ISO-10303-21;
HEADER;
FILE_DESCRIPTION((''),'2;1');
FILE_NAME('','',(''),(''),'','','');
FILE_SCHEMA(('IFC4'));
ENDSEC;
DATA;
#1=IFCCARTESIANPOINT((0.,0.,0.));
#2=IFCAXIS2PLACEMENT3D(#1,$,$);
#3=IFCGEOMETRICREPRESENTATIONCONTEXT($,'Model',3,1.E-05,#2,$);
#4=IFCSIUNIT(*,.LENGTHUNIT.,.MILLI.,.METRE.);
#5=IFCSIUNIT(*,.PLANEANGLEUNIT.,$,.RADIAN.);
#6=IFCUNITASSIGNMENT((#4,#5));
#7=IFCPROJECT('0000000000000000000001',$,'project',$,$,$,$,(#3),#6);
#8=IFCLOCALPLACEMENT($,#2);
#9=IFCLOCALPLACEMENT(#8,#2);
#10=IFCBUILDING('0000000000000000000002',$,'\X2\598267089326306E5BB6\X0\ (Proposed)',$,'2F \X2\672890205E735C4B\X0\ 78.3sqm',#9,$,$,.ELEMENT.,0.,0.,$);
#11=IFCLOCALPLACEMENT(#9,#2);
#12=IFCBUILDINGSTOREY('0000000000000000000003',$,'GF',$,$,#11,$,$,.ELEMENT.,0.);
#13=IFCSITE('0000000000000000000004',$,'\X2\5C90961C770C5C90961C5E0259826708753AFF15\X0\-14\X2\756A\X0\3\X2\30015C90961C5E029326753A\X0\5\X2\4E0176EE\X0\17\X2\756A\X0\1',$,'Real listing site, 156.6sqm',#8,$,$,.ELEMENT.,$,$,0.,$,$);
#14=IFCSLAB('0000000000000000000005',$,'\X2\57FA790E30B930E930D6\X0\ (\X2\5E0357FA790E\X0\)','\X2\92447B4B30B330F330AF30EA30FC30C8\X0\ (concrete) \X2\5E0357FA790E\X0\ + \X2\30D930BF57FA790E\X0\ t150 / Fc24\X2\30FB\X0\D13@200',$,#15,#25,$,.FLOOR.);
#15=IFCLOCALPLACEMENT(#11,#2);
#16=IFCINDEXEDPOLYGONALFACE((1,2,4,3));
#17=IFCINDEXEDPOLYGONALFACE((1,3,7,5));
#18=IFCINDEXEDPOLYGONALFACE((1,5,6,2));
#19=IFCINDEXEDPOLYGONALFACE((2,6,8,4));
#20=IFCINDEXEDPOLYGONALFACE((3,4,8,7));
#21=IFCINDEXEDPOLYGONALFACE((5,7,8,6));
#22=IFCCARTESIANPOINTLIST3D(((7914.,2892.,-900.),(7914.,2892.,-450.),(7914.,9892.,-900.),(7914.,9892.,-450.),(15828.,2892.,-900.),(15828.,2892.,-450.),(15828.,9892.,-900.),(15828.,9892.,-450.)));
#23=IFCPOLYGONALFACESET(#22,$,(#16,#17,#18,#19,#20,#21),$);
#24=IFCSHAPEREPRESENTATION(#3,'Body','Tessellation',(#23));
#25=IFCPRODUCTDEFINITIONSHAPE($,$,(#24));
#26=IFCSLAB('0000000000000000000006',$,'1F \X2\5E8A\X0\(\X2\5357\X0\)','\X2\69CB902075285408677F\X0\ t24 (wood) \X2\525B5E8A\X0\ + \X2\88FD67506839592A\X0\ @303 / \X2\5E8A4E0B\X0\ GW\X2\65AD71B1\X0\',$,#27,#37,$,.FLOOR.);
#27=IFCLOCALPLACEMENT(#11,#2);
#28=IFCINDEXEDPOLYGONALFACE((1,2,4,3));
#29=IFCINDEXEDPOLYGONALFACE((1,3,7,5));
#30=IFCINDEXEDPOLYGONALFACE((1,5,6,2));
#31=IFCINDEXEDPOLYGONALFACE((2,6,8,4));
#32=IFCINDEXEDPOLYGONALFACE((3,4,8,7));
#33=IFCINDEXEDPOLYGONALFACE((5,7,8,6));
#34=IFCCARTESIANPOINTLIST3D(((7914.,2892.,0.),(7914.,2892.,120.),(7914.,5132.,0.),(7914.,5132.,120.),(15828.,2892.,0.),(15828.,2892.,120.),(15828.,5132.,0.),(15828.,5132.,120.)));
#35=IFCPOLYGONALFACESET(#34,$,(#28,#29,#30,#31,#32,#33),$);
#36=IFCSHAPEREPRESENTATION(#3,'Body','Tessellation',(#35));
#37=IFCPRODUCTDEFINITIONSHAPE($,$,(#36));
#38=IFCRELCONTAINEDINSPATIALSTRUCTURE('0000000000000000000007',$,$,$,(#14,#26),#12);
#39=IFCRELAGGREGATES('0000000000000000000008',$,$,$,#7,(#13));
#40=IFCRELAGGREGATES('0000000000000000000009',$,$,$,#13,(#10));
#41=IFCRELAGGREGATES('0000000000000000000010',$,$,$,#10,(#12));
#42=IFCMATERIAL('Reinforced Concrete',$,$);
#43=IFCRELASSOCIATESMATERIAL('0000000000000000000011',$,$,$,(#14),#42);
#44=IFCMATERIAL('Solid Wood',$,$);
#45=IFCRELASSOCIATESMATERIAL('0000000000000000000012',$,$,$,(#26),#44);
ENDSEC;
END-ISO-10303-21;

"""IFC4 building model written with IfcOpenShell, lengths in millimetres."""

from ifc_helpers import new_model, si_unit, frame, frame_2d, origin, place, context, project, spatial, rectangle, extrude, material, element, save


model = new_model("IFC4")

# Units and contexts
model_context = context("Model", 3, precision=1e-05, world=origin())
ifc_project = project(units=[si_unit("LENGTHUNIT", "METRE", prefix="MILLI"), si_unit("PLANEANGLEUNIT", "RADIAN")], contexts=[model_context])

# Site, building, storey
site_placement = place(None, origin())
site = spatial("IfcSite", under=ifc_project, at=site_placement, Name="岐阜県岐阜市如月町５-14番3、岐阜市錦町5丁目17番1", ObjectType="Real listing site, 156.6sqm", CompositionType="ELEMENT", RefElevation=0.0)
building_placement = place(site_placement, origin())
building = spatial("IfcBuilding", under=site, at=building_placement, Name="如月錦の家 (Proposed)", ObjectType="2F 木造平屋 78.3sqm", CompositionType="ELEMENT", ElevationOfRefHeight=0.0, ElevationOfTerrain=0.0)
storey_placement = place(building_placement, origin())
storey = spatial("IfcBuildingStorey", under=building, at=storey_placement, Name="GF", CompositionType="ELEMENT", Elevation=0.0)

# Slabs
ifc_material_1 = material(Name="Reinforced Concrete")
slab_1_placement = place(storey_placement, frame((3957.0, 1446.0, -450.0)))
element("IfcSlab", 1, at=slab_1_placement, inside=storey, material=ifc_material_1, Name="基礎スラブ (布基礎)", Description="鉄筋コンクリート (concrete) 布基礎 + ベタ基礎 t150 / Fc24・D13@200", PredefinedType="FLOOR", context=model_context, shape_type="SweptSolid", body=[
    extrude(rectangle(XDim=7914.0, YDim=7000.0, at=frame_2d((3957.0, 3500.0))), frame((3957.0, 1446.0, -450.0)), (0.0, 0.0, 1.0), 450.0),
])
ifc_material_2 = material(Name="Solid Wood")
slab_2_placement = place(storey_placement, frame((3957.0, 1446.0, 0.0)))
element("IfcSlab", 2, at=slab_2_placement, inside=storey, material=ifc_material_2, Name="1F 床(南)", Description="構造用合板 t24 (wood) 剛床 + 製材根太 @303 / 床下 GW断熱", PredefinedType="FLOOR", context=model_context, shape_type="SweptSolid", body=[
    extrude(rectangle(XDim=7914.0, YDim=2240.0, at=frame_2d((3957.0, 1120.0))), frame((3957.0, 1446.0, 0.0)), (0.0, 0.0, 1.0), 120.0),
])

save(model, "model.ifc")
